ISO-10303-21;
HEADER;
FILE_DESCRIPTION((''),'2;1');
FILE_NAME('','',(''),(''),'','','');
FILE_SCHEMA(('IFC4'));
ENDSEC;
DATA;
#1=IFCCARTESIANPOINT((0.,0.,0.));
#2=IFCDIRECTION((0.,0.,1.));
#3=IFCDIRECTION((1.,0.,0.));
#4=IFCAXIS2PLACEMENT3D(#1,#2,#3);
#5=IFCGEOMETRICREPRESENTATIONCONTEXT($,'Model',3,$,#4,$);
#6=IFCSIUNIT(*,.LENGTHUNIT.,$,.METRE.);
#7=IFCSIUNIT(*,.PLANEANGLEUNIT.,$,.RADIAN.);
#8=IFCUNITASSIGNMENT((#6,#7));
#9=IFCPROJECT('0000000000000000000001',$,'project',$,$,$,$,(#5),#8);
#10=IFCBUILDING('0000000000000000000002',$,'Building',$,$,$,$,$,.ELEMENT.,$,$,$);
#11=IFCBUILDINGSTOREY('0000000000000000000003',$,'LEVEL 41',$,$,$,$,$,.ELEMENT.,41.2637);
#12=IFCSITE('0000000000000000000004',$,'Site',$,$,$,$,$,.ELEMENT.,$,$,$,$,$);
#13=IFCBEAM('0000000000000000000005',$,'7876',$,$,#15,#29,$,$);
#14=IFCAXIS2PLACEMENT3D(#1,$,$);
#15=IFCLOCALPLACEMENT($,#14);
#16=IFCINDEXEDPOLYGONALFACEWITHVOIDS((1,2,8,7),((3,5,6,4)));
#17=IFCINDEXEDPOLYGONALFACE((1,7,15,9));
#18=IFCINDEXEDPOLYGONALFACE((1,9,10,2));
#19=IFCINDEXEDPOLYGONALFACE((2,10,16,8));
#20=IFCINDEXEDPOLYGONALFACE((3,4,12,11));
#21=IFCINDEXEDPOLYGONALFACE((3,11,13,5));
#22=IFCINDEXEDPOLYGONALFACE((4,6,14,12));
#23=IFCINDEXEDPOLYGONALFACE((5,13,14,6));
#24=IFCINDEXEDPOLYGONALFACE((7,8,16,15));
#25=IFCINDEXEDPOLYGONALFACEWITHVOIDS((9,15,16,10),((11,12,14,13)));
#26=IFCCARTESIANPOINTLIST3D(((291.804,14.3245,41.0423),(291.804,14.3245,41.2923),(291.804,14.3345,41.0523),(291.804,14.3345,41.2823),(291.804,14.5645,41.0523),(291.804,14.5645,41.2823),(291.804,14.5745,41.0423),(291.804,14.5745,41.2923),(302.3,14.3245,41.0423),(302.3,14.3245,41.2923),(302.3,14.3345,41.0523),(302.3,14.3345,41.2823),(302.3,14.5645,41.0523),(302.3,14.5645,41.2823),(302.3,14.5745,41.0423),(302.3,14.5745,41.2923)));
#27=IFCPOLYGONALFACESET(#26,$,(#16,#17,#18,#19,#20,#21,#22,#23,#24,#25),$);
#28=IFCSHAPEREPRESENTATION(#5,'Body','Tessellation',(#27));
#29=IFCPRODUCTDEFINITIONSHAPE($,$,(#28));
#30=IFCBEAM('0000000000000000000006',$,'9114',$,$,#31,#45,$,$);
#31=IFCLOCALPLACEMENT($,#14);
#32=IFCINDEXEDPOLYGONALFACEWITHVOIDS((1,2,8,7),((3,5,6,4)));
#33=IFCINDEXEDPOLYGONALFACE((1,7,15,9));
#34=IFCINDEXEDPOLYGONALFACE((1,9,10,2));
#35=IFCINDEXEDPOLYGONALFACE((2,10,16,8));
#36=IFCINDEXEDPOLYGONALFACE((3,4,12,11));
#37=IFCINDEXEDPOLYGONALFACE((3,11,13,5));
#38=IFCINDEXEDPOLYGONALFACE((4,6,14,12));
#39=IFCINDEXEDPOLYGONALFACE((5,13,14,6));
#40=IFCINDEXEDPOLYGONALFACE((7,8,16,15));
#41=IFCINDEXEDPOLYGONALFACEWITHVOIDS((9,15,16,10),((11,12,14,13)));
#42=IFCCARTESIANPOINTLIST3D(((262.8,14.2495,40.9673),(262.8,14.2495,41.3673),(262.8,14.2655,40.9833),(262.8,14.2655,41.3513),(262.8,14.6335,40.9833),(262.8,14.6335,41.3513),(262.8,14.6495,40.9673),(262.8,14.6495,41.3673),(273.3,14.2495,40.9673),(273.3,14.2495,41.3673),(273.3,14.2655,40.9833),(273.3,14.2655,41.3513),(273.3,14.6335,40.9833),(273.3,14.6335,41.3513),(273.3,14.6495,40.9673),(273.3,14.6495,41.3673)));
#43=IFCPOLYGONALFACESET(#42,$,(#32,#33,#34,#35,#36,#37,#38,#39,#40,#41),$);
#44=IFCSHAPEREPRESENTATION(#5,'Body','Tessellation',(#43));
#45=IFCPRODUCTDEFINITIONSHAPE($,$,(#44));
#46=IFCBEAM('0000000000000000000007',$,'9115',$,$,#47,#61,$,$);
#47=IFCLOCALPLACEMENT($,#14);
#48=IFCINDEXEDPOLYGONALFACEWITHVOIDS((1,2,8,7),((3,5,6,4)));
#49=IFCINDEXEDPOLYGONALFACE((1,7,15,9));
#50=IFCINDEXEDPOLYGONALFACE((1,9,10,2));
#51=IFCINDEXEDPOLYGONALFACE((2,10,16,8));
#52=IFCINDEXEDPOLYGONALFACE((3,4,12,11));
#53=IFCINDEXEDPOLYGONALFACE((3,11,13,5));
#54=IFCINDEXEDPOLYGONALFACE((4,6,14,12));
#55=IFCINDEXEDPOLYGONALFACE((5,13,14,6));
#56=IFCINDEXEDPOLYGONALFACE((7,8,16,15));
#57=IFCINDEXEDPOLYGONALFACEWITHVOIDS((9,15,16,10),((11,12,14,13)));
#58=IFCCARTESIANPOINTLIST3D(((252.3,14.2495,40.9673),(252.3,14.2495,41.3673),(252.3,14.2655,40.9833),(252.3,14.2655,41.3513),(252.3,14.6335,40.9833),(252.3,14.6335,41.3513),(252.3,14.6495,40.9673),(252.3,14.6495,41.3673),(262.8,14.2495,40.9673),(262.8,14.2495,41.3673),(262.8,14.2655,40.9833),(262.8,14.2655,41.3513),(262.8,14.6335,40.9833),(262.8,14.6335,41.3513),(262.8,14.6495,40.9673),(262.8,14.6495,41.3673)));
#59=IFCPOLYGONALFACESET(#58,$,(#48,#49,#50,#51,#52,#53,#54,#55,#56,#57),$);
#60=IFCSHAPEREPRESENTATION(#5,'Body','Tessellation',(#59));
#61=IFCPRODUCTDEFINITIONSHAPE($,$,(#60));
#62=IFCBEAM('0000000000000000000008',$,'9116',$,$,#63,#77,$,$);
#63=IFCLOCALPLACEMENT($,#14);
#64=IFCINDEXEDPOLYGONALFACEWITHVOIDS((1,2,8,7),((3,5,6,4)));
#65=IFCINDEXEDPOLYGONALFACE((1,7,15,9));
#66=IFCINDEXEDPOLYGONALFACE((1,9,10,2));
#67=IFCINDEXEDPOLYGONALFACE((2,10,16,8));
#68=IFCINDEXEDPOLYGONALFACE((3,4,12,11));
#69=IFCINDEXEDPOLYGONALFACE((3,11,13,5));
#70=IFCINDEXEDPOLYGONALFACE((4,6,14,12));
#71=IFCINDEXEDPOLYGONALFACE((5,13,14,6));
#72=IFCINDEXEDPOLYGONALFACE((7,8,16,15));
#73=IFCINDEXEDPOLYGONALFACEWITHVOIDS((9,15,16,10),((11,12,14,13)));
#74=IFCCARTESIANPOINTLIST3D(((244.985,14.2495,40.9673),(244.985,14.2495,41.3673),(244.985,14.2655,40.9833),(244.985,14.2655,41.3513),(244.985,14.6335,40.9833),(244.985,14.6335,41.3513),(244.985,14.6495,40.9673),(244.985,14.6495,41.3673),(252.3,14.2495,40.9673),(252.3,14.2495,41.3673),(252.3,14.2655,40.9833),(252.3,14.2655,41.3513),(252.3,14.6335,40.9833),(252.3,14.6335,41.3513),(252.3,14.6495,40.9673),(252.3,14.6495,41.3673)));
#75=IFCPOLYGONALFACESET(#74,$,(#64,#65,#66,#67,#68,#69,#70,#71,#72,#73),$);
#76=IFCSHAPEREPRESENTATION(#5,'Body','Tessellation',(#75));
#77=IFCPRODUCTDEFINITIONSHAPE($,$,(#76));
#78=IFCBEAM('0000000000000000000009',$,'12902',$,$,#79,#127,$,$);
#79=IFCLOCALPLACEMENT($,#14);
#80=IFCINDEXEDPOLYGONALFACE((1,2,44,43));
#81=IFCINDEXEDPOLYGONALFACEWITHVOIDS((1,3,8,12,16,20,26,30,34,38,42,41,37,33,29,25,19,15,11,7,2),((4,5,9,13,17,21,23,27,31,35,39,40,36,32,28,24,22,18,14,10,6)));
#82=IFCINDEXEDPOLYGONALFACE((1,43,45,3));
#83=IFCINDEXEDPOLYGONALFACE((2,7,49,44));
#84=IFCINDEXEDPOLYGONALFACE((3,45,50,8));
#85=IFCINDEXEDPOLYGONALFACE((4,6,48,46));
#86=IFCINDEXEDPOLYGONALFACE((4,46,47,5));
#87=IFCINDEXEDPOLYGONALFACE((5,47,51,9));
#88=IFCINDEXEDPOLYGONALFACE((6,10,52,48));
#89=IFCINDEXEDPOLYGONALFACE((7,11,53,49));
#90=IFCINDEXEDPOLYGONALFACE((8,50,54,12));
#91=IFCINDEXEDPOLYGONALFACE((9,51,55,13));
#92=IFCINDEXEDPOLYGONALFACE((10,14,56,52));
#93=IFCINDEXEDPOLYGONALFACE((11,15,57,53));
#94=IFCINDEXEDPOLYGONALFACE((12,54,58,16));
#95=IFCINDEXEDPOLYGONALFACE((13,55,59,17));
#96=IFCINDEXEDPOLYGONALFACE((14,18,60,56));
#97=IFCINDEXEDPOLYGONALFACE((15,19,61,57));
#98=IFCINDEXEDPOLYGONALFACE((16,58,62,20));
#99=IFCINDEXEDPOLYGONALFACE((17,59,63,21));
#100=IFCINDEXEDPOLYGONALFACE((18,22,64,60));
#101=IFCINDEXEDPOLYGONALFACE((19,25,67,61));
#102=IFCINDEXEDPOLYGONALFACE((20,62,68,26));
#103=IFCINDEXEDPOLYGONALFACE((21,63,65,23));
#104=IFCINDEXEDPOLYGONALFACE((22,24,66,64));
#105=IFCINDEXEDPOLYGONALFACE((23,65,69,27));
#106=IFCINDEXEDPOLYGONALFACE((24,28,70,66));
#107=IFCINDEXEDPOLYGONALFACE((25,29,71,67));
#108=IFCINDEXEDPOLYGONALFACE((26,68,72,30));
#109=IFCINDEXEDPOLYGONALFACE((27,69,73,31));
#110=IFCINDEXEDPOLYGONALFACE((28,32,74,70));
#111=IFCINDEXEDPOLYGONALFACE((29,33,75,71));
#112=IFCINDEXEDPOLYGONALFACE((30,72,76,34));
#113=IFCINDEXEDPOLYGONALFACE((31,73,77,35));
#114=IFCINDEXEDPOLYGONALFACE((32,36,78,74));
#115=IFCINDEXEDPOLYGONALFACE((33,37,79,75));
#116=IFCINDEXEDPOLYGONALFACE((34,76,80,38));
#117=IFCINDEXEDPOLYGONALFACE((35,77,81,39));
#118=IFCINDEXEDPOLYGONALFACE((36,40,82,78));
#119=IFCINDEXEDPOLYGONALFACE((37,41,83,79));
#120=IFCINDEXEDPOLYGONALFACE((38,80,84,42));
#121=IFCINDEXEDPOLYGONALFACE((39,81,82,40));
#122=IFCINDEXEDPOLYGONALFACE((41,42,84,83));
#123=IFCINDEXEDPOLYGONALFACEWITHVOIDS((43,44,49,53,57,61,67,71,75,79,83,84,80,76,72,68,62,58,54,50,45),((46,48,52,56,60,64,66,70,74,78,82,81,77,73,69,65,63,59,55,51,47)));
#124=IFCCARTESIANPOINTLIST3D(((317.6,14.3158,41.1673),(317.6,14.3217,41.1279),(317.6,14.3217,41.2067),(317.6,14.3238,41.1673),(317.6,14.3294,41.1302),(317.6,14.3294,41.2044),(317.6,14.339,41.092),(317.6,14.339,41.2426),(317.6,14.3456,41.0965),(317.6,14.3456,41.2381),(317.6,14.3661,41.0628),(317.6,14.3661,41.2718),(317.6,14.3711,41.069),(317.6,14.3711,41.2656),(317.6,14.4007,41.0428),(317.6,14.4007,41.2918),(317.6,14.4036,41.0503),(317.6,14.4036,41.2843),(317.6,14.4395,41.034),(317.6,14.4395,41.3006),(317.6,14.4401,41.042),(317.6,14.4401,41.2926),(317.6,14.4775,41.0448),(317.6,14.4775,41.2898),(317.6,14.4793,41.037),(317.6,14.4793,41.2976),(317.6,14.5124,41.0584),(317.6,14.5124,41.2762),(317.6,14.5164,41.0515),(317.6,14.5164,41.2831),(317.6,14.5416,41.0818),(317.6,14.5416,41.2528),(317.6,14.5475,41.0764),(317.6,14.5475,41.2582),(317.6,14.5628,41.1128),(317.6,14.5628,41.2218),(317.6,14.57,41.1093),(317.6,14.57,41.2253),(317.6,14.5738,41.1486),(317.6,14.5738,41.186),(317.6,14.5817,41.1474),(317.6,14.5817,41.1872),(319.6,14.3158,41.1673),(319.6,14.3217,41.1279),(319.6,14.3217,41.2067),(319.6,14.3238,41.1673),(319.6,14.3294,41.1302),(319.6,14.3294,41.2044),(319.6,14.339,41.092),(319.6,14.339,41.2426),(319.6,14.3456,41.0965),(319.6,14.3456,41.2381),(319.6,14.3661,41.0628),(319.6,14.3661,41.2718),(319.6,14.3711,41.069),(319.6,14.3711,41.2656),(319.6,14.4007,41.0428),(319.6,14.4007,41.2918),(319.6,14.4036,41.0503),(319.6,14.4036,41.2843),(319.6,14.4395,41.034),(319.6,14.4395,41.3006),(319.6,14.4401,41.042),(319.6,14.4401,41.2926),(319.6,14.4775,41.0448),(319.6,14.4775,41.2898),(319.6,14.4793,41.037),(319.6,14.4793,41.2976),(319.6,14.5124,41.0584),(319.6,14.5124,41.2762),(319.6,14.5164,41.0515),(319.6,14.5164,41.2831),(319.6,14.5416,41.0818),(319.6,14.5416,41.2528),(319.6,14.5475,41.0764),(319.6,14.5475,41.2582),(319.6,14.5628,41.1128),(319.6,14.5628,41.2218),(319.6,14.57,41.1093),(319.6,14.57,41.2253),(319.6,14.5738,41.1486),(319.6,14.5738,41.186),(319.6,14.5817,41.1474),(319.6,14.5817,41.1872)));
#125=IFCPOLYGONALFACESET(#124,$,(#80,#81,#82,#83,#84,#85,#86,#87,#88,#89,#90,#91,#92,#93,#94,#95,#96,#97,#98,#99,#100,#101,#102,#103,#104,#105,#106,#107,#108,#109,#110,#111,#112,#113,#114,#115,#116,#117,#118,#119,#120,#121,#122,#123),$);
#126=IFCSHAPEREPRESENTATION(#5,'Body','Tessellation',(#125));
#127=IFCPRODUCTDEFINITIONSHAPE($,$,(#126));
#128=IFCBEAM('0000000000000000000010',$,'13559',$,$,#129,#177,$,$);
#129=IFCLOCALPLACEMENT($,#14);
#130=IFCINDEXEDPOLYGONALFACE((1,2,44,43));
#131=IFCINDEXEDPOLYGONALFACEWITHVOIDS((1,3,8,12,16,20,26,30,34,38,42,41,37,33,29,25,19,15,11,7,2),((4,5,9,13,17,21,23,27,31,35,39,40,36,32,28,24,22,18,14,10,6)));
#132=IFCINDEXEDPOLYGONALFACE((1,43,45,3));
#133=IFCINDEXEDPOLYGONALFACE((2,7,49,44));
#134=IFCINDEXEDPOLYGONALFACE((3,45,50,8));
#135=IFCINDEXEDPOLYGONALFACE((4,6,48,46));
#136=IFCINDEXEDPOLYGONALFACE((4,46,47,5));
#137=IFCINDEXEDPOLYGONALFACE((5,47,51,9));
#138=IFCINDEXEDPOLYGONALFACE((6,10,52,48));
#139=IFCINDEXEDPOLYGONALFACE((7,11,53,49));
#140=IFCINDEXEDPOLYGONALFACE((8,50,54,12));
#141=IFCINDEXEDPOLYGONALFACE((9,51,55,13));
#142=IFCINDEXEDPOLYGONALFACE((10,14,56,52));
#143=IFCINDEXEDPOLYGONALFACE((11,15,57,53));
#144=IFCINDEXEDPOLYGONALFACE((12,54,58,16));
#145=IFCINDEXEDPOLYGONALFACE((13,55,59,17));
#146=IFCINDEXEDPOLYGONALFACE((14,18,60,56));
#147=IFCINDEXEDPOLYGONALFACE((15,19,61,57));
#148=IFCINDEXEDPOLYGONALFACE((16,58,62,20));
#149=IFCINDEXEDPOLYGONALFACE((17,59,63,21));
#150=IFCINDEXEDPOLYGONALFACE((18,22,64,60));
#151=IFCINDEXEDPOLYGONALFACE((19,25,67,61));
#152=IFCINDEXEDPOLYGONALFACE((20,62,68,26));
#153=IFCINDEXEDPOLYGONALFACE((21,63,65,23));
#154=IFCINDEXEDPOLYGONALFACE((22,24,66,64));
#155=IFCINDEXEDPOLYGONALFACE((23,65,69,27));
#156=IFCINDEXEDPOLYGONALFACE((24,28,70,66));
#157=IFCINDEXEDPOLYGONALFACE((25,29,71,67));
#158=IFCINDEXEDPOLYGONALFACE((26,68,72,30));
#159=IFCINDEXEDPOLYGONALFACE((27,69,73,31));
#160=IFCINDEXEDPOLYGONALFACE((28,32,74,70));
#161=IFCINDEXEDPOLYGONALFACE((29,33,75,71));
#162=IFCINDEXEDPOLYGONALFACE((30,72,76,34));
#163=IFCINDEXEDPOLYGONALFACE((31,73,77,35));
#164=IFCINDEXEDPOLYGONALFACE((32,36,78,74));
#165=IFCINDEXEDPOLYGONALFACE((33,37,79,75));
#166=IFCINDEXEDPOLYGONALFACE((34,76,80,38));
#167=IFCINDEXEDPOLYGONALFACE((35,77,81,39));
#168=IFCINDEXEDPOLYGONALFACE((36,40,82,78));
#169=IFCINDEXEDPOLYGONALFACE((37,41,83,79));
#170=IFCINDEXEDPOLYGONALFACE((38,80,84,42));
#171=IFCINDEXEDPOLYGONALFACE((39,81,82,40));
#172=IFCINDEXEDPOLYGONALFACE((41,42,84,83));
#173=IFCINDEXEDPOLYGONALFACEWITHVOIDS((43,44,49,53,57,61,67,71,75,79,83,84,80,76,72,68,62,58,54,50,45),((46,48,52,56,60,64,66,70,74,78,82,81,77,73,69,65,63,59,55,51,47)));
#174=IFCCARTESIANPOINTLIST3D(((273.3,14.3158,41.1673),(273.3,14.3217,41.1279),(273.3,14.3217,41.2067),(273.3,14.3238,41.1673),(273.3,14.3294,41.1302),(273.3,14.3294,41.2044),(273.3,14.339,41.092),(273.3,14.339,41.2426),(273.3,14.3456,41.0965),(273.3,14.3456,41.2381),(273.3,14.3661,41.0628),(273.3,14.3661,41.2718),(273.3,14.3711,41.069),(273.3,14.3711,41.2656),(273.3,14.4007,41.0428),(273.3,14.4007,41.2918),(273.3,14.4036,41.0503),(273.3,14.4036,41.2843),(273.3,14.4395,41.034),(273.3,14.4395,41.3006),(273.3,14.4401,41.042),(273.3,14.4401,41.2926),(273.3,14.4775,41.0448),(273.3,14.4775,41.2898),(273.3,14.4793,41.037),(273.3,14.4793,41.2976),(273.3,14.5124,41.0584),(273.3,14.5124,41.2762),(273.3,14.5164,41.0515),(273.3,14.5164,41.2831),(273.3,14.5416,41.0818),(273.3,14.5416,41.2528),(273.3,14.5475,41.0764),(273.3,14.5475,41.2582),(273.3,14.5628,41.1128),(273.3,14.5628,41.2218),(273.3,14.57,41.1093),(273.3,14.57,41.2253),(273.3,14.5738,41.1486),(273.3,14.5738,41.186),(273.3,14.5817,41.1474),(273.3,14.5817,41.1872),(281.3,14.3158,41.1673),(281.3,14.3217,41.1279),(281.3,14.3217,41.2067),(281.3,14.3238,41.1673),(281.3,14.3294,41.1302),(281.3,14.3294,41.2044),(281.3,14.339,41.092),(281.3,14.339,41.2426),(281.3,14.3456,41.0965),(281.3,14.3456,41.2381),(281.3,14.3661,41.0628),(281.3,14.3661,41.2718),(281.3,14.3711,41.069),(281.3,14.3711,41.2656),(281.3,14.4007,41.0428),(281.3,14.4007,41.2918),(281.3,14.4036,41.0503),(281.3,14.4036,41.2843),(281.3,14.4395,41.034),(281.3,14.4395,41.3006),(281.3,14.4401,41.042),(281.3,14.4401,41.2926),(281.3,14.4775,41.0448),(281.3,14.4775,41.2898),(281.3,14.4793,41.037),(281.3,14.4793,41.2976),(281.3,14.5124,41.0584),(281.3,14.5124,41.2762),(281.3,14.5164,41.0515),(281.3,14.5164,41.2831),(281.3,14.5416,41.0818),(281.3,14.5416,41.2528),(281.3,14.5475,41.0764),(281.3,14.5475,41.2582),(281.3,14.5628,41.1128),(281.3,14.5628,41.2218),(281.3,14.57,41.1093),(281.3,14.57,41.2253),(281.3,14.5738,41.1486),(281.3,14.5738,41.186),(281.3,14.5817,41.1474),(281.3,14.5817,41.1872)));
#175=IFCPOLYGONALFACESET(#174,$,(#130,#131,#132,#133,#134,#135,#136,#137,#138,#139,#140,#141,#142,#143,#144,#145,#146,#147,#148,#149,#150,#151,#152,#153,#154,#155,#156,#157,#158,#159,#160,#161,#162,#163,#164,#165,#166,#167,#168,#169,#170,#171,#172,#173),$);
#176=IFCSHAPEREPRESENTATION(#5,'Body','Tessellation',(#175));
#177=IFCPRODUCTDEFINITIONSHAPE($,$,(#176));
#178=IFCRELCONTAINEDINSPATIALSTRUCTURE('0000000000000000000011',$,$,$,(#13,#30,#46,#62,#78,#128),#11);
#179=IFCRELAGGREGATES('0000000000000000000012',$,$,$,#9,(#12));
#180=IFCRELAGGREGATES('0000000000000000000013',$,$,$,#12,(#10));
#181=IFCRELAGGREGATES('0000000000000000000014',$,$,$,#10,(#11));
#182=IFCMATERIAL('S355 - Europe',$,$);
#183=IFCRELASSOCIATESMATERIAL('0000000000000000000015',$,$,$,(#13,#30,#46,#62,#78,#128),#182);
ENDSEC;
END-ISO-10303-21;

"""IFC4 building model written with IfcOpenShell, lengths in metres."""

from ifc_helpers import new_model, si_unit, frame, origin_with_axes, origin_2d_with_axis, place, context, project, spatial, hollow_rectangle, hollow_circle, extrude, material, material_profile, profile_set, profile_usage, element, save


model = new_model("IFC4")

# Units and contexts
model_context = context("Model", 3, world=origin_with_axes())
ifc_project = project(units=[si_unit("LENGTHUNIT", "METRE"), si_unit("PLANEANGLEUNIT", "RADIAN")], contexts=[model_context])

# Site, building, storey
site = spatial("IfcSite", under=ifc_project, Name="Site", CompositionType="ELEMENT")
building = spatial("IfcBuilding", under=site, Name="Building", CompositionType="ELEMENT")
storey = spatial("IfcBuildingStorey", under=building, Name="LEVEL 41", CompositionType="ELEMENT", Elevation=41.2637)

# Beams
ifc_material = material(Name="S355 - Europe")
ifc_material_profile_1 = material_profile(ifc_material, hollow_rectangle(XDim=0.25, YDim=0.25, WallThickness=0.01, at=origin_2d_with_axis()))
ifc_profile_set_1 = profile_set([ifc_material_profile_1])
ifc_profile_usage_1 = profile_usage(ifc_profile_set_1, cardinal=10)
beam_1_placement = place(None, frame((302.3, 14.4495, 41.1673), z_axis=(-1.0, 0.0, 0.0), x_axis=(0.0, -1.0, 0.0)))
element("IfcBeam", 1, at=beam_1_placement, inside=storey, material=ifc_profile_usage_1, Name="7876", context=model_context, shape_type="SweptSolid", body=[
    extrude(hollow_rectangle(XDim=0.25, YDim=0.25, WallThickness=0.01, at=origin_2d_with_axis()), origin_with_axes(), (0.0, 0.0, 1.0), 10.496),
])
ifc_material_profile_2 = material_profile(ifc_material, hollow_rectangle(XDim=0.4, YDim=0.4, WallThickness=0.016, at=origin_2d_with_axis()))
ifc_profile_set_2 = profile_set([ifc_material_profile_2])
ifc_profile_usage_2 = profile_usage(ifc_profile_set_2, cardinal=10)
beam_2_placement = place(None, frame((273.3, 14.4495, 41.1673), z_axis=(-1.0, 0.0, 0.0), x_axis=(0.0, -1.0, 0.0)))
element("IfcBeam", 2, at=beam_2_placement, inside=storey, material=ifc_profile_usage_2, Name="9114", context=model_context, shape_type="SweptSolid", body=[
    extrude(hollow_rectangle(XDim=0.4, YDim=0.4, WallThickness=0.016, at=origin_2d_with_axis()), origin_with_axes(), (0.0, 0.0, 1.0), 10.5),
])
ifc_material_profile_3 = material_profile(ifc_material, hollow_rectangle(XDim=0.4, YDim=0.4, WallThickness=0.016, at=origin_2d_with_axis()))
ifc_profile_set_3 = profile_set([ifc_material_profile_3])
ifc_profile_usage_3 = profile_usage(ifc_profile_set_3, cardinal=10)
beam_3_placement = place(None, frame((262.8, 14.4495, 41.1673), z_axis=(-1.0, 0.0, 0.0), x_axis=(0.0, -1.0, 0.0)))
element("IfcBeam", 3, at=beam_3_placement, inside=storey, material=ifc_profile_usage_3, Name="9115", context=model_context, shape_type="SweptSolid", body=[
    extrude(hollow_rectangle(XDim=0.4, YDim=0.4, WallThickness=0.016, at=origin_2d_with_axis()), origin_with_axes(), (0.0, 0.0, 1.0), 10.5),
])
ifc_material_profile_4 = material_profile(ifc_material, hollow_rectangle(XDim=0.4, YDim=0.4, WallThickness=0.016, at=origin_2d_with_axis()))
ifc_profile_set_4 = profile_set([ifc_material_profile_4])
ifc_profile_usage_4 = profile_usage(ifc_profile_set_4, cardinal=10)
beam_4_placement = place(None, frame((252.3, 14.4495, 41.1673), z_axis=(-1.0, 0.0, 0.0), x_axis=(0.0, -1.0, 0.0)))
element("IfcBeam", 4, at=beam_4_placement, inside=storey, material=ifc_profile_usage_4, Name="9116", context=model_context, shape_type="SweptSolid", body=[
    extrude(hollow_rectangle(XDim=0.4, YDim=0.4, WallThickness=0.016, at=origin_2d_with_axis()), origin_with_axes(), (0.0, 0.0, 1.0), 7.315),
])
ifc_material_profile_5 = material_profile(ifc_material, hollow_circle(Radius=0.1337, WallThickness=0.008, at=origin_2d_with_axis()))
ifc_profile_set_5 = profile_set([ifc_material_profile_5])
ifc_profile_usage_5 = profile_usage(ifc_profile_set_5, cardinal=10)
beam_5_placement = place(None, frame((319.6, 14.4495, 41.1673), z_axis=(-1.0, 0.0, 0.0), x_axis=(0.0, -1.0, 0.0)))
element("IfcBeam", 5, at=beam_5_placement, inside=storey, material=ifc_profile_usage_5, Name="12902", context=model_context, shape_type="SweptSolid", body=[
    extrude(hollow_circle(Radius=0.1337, WallThickness=0.008, at=origin_2d_with_axis()), origin_with_axes(), (0.0, 0.0, 1.0), 2.0),
])
ifc_material_profile_6 = material_profile(ifc_material, hollow_circle(Radius=0.1337, WallThickness=0.008, at=origin_2d_with_axis()))
ifc_profile_set_6 = profile_set([ifc_material_profile_6])
ifc_profile_usage_6 = profile_usage(ifc_profile_set_6, cardinal=10)
beam_6_placement = place(None, frame((281.3, 14.4495, 41.1673), z_axis=(-1.0, 0.0, 0.0), x_axis=(0.0, -1.0, 0.0)))
element("IfcBeam", 6, at=beam_6_placement, inside=storey, material=ifc_profile_usage_6, Name="13559", context=model_context, shape_type="SweptSolid", body=[
    extrude(hollow_circle(Radius=0.1337, WallThickness=0.008, at=origin_2d_with_axis()), origin_with_axes(), (0.0, 0.0, 1.0), 8.0),
])

save(model, "model.ifc")
